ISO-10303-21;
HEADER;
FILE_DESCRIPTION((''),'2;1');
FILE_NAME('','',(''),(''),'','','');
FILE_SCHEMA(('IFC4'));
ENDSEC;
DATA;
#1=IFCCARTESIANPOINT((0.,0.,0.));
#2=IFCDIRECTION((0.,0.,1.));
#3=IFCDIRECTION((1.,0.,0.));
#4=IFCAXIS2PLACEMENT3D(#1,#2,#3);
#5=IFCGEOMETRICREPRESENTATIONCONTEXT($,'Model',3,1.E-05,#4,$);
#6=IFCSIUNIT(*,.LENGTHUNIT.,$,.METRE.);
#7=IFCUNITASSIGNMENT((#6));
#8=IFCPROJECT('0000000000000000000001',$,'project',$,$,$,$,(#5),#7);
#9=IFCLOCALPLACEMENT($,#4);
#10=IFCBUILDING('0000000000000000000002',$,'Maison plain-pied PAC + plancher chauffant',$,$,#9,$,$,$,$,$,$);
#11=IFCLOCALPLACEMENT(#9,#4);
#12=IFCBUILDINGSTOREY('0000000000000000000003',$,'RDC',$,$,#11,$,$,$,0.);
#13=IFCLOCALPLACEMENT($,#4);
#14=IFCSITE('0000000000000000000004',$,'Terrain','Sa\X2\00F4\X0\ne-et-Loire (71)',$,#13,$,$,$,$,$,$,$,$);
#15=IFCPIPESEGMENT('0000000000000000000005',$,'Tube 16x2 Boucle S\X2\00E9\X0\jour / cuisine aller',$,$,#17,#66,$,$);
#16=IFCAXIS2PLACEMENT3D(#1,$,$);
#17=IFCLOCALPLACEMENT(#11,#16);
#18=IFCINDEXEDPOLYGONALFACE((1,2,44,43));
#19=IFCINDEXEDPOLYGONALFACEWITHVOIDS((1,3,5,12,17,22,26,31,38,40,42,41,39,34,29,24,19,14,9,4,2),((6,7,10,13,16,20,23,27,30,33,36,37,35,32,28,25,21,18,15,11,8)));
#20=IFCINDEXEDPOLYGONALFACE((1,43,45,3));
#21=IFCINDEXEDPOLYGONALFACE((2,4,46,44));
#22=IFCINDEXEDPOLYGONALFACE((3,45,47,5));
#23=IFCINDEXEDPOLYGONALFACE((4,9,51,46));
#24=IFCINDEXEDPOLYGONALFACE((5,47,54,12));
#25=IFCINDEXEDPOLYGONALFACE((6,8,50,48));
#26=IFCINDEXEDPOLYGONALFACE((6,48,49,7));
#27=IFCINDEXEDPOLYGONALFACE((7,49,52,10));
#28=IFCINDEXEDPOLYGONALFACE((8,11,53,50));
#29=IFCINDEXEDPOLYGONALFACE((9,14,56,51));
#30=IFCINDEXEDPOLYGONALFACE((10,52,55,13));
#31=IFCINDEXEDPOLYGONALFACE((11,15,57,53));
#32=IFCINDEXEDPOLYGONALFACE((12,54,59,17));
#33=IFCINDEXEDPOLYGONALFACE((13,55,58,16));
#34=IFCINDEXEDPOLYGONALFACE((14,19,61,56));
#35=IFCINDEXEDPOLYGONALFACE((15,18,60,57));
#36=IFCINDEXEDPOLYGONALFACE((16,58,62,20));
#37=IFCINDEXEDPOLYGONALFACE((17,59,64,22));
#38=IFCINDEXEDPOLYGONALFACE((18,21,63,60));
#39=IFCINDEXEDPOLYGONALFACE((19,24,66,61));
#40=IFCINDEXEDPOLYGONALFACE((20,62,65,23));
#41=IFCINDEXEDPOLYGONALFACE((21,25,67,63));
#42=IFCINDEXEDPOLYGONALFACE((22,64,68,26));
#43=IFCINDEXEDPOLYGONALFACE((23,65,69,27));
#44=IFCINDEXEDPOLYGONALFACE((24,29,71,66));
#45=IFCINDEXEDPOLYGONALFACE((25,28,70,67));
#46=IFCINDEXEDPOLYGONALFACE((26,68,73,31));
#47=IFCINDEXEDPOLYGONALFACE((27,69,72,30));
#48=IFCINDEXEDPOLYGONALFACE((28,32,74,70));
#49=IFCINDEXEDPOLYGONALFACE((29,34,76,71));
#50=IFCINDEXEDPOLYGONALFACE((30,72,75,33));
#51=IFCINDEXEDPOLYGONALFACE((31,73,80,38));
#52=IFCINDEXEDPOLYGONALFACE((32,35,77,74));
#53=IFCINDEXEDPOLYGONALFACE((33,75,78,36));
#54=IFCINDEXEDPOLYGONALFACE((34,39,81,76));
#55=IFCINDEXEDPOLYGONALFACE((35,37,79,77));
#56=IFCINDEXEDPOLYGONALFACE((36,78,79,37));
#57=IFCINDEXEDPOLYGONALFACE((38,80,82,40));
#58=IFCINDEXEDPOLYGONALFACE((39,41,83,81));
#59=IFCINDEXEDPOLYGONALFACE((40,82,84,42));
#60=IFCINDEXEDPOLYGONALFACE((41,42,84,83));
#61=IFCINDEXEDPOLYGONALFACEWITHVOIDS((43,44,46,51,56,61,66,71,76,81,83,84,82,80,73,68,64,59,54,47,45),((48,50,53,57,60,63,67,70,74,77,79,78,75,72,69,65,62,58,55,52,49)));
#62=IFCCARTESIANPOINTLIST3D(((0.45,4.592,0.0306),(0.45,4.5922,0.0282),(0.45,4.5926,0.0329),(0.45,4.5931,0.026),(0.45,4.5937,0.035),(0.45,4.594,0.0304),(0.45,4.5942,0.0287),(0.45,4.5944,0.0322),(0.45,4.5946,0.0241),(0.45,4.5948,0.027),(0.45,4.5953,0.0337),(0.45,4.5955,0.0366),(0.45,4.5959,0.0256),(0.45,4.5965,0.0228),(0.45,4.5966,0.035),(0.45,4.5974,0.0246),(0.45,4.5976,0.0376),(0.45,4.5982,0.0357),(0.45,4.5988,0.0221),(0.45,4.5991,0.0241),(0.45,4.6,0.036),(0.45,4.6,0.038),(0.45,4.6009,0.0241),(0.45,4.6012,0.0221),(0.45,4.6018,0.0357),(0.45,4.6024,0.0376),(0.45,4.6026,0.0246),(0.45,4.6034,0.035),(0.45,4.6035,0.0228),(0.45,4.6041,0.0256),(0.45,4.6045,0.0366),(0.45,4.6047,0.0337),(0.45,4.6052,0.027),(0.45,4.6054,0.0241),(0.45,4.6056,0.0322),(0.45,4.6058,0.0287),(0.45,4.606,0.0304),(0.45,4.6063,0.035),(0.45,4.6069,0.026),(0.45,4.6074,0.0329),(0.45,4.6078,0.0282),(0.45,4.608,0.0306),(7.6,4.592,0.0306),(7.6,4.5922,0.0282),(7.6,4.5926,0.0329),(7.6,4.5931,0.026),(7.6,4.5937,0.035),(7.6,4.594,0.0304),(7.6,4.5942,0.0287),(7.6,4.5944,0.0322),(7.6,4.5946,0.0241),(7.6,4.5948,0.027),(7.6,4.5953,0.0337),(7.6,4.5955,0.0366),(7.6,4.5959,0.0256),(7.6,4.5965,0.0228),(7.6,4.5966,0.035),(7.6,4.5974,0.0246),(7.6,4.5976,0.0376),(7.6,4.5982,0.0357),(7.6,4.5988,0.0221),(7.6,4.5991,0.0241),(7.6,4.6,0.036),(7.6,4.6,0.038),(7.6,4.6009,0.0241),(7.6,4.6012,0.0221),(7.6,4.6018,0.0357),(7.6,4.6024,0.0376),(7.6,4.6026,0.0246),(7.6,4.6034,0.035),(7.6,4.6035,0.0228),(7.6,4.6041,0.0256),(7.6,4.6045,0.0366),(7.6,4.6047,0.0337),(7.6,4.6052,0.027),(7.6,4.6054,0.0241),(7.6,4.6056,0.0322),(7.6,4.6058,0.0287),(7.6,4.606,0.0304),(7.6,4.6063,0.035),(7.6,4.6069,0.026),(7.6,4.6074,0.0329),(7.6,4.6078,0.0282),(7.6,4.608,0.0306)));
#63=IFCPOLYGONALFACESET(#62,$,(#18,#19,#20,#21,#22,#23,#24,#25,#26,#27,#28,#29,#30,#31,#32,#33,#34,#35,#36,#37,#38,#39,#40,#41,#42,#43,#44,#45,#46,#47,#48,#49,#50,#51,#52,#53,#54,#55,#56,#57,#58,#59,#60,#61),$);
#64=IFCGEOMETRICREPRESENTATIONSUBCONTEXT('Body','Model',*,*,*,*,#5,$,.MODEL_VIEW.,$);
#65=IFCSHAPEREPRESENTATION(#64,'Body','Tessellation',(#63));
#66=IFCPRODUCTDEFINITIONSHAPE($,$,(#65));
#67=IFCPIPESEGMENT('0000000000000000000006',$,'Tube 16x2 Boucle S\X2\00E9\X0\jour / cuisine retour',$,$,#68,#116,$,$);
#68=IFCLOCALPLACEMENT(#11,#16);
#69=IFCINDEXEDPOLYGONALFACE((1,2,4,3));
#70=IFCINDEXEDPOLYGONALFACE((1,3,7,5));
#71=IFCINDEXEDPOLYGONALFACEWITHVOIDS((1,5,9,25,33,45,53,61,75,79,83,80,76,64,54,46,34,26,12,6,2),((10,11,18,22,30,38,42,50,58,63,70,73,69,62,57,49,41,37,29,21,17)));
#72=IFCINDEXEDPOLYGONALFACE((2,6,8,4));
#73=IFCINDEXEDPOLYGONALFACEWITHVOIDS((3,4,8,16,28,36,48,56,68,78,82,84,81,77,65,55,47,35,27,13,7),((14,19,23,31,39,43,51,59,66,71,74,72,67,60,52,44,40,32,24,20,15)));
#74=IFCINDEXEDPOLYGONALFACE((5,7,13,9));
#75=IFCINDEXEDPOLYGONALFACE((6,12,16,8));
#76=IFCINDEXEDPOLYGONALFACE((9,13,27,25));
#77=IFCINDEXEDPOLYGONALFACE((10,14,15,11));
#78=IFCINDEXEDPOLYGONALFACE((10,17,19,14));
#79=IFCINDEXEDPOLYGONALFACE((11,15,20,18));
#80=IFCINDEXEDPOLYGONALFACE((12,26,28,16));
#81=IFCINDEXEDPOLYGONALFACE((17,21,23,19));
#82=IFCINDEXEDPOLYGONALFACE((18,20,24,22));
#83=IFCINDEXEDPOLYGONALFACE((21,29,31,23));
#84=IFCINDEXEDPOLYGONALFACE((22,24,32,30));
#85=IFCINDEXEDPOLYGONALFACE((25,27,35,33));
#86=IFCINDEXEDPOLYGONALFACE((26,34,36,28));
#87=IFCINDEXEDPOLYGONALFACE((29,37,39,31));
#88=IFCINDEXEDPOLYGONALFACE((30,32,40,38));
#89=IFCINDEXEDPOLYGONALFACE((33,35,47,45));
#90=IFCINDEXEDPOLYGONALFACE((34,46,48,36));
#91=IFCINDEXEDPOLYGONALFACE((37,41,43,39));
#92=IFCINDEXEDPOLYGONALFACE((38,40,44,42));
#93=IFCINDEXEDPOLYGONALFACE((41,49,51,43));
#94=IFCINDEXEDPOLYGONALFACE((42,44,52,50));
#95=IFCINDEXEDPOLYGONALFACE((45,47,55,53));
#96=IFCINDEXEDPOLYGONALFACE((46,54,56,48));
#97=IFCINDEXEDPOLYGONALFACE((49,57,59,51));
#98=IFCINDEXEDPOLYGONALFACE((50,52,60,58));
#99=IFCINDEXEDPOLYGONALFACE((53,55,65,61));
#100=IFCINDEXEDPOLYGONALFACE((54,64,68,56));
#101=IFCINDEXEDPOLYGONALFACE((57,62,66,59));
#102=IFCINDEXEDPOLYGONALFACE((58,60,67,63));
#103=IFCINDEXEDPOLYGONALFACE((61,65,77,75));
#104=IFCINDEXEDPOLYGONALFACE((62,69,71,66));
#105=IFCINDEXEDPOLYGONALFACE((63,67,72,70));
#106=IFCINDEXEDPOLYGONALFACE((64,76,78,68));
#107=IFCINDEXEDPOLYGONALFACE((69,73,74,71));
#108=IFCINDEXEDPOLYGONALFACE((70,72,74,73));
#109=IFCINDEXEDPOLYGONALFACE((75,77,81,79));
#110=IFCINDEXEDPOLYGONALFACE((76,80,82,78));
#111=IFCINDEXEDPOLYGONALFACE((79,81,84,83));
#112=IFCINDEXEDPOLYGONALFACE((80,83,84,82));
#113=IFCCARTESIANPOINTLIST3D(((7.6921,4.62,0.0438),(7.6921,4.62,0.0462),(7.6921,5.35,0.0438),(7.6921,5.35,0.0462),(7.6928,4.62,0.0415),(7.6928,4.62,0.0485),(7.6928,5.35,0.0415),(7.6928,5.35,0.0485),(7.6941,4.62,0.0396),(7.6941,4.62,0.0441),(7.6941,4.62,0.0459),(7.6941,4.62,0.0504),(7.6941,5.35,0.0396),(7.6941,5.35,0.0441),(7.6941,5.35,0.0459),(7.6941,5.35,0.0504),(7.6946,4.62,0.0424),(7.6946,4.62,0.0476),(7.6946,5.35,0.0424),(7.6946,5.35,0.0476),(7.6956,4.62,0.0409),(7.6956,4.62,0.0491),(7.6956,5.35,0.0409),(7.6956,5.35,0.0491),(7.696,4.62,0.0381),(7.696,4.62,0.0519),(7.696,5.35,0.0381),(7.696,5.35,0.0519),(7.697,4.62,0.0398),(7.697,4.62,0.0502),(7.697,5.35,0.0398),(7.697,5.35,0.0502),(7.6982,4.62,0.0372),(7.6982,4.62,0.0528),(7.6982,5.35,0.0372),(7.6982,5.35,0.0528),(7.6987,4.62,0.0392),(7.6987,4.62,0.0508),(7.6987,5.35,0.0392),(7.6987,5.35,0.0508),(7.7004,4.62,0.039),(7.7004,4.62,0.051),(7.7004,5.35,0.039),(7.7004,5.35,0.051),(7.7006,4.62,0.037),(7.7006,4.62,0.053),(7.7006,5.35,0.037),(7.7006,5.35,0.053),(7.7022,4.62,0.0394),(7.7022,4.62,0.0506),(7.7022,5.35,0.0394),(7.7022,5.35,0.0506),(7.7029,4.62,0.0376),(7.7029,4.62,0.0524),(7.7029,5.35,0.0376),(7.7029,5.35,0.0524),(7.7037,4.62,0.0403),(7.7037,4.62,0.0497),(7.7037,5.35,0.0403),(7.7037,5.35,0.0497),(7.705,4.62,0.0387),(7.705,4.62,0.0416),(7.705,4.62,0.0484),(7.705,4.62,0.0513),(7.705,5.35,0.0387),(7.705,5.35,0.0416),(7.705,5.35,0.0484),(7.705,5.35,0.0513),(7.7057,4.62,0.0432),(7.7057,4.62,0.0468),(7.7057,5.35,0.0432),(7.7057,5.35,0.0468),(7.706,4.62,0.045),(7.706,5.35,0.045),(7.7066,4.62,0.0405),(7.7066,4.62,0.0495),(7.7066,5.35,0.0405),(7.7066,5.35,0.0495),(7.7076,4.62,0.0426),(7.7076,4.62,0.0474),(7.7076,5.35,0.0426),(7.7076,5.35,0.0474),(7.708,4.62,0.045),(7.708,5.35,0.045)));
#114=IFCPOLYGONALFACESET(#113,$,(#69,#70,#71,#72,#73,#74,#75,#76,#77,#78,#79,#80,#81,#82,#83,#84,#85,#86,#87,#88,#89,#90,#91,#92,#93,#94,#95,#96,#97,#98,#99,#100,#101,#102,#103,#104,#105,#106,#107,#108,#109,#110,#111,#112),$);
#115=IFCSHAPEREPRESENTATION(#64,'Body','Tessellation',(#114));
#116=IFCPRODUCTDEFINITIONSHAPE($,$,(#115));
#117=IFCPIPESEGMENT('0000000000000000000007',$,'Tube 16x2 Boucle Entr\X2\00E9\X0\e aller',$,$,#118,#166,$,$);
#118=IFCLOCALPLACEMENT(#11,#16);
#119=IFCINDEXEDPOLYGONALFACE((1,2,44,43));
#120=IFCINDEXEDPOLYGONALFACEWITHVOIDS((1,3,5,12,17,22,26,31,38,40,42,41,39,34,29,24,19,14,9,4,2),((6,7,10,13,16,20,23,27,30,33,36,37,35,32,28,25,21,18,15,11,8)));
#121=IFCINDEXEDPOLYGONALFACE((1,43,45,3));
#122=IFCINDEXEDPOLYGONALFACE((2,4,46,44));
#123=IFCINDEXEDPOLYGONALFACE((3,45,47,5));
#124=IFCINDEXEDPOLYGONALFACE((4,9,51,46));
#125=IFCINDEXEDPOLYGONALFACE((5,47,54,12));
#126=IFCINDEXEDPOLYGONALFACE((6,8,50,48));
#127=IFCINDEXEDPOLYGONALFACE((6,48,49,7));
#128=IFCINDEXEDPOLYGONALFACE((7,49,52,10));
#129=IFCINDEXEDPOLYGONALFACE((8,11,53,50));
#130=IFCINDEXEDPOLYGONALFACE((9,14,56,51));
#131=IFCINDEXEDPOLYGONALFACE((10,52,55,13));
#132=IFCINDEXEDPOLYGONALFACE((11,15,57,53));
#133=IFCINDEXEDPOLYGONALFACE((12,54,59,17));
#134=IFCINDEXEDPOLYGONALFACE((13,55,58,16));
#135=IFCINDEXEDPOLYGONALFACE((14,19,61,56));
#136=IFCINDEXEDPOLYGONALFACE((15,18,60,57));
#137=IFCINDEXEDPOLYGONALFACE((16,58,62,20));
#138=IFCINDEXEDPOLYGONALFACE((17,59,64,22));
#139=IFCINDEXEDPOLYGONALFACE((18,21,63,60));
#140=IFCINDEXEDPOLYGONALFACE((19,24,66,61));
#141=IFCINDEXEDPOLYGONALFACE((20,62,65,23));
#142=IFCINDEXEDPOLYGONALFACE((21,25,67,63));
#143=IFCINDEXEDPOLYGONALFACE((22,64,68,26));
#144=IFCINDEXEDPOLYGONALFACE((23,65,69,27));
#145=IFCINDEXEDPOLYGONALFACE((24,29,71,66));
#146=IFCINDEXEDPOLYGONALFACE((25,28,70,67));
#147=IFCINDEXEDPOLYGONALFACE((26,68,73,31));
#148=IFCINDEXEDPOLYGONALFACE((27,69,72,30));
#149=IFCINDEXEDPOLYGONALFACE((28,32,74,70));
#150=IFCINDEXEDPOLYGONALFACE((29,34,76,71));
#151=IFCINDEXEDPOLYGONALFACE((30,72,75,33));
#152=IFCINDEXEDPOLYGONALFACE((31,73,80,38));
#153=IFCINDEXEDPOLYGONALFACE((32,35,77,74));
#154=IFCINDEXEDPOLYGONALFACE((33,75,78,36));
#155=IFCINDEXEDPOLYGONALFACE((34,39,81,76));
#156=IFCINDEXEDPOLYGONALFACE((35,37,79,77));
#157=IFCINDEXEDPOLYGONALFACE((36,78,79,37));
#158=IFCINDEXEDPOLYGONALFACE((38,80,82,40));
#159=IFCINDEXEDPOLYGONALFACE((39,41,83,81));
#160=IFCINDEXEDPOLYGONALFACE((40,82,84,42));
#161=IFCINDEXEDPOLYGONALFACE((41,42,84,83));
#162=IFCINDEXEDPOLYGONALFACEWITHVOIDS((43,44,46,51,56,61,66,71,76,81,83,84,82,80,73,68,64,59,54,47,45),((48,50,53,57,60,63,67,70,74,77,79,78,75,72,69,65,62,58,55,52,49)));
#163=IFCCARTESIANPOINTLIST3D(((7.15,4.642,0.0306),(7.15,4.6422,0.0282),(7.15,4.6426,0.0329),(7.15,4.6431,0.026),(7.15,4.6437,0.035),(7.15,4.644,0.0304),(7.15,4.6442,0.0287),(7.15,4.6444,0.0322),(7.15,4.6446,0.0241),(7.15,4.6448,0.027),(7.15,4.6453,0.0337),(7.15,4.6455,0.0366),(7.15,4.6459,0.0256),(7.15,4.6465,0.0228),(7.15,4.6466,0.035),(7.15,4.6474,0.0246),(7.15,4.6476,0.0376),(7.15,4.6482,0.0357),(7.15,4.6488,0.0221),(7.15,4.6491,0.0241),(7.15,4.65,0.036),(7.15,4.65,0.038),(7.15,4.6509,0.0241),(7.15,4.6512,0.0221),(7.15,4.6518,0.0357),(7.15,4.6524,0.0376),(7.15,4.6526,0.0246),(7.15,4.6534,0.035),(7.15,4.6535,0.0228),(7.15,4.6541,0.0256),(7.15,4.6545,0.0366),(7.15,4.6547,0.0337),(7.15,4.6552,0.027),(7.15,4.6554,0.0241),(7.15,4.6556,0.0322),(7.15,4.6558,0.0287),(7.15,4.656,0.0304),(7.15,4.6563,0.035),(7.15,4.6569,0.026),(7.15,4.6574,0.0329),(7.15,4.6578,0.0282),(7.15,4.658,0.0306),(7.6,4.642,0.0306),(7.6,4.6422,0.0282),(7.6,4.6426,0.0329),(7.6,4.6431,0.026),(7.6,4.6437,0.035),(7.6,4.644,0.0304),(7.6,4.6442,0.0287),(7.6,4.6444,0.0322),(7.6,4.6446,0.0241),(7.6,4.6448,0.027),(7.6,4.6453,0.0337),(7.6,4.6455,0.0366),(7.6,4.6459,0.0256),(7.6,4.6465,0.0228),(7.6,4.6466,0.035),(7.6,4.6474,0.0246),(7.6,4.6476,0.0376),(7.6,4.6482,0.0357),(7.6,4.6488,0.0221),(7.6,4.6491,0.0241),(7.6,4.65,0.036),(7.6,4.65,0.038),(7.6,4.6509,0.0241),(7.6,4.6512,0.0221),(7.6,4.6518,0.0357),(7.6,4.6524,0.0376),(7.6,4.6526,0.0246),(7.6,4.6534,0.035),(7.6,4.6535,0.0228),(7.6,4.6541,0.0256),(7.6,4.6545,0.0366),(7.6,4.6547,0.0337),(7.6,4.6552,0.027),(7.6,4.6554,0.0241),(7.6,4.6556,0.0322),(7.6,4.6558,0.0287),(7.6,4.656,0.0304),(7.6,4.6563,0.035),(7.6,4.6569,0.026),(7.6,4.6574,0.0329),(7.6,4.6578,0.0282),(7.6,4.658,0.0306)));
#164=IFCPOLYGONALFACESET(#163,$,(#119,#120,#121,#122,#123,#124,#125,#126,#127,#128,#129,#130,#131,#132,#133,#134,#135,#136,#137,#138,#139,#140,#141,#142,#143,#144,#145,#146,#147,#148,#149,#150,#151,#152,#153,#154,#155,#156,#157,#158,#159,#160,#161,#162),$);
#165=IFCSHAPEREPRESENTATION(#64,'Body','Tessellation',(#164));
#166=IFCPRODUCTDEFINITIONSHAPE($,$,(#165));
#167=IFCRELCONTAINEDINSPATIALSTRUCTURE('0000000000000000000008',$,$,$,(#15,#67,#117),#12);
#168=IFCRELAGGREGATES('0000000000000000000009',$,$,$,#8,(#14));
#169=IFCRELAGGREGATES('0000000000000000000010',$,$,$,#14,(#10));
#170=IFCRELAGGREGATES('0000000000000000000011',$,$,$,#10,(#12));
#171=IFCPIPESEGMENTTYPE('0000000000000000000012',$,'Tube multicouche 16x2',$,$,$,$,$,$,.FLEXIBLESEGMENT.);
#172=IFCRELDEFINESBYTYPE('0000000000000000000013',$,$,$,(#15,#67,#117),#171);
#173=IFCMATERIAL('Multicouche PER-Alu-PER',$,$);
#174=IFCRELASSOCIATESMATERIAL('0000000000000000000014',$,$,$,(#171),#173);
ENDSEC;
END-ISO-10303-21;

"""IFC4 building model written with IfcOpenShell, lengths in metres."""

from ifc_helpers import new_model, si_unit, frame, origin_with_axes, place, context, subcontext, project, spatial, hollow_circle, extrude, material, type_object, element, save


model = new_model("IFC4")

# Units and contexts
model_context = context("Model", 3, precision=1e-05, world=origin_with_axes())
body_context = subcontext(model_context, "Body", "Model", "MODEL_VIEW")
ifc_project = project(units=[si_unit("LENGTHUNIT", "METRE")], contexts=[model_context])

# Site, building, storey
site_placement = place(None, origin_with_axes())
site = spatial("IfcSite", under=ifc_project, at=site_placement, Name="Terrain", Description="Saône-et-Loire (71)")
building_placement = place(None, origin_with_axes())
building = spatial("IfcBuilding", under=site, at=building_placement, Name="Maison plain-pied PAC + plancher chauffant")
storey_placement = place(building_placement, origin_with_axes())
storey = spatial("IfcBuildingStorey", under=building, at=storey_placement, Name="RDC", Elevation=0.0)

# Pipe segments
ifc_material = material(Name="Multicouche PER-Alu-PER")
pipe_segment_type = type_object("IfcPipeSegmentType", Name="Tube multicouche 16x2", PredefinedType="FLEXIBLESEGMENT", material=ifc_material)
pipe_segment_1_placement = place(storey_placement, frame((7.6, 4.6, 0.03), z_axis=(-1.0, 0.0, 0.0), x_axis=(0.0, 0.0, 1.0)))
element("IfcPipeSegment", 1, at=pipe_segment_1_placement, inside=storey, type_object=pipe_segment_type, Name="Tube 16x2 Boucle Séjour / cuisine aller", context=body_context, shape_type="SweptSolid", body=[
    extrude(hollow_circle(Radius=0.008, WallThickness=0.002), origin_with_axes(), (0.0, 0.0, 1.0), 7.15),
])
pipe_segment_2_placement = place(storey_placement, frame((7.7, 4.62, 0.045), z_axis=(0.0, 1.0, 0.0), x_axis=(1.0, 0.0, 0.0)))
element("IfcPipeSegment", 2, at=pipe_segment_2_placement, inside=storey, type_object=pipe_segment_type, Name="Tube 16x2 Boucle Séjour / cuisine retour", context=body_context, shape_type="SweptSolid", body=[
    extrude(hollow_circle(Radius=0.008, WallThickness=0.002), origin_with_axes(), (0.0, 0.0, 1.0), 0.73),
])
pipe_segment_3_placement = place(storey_placement, frame((7.6, 4.65, 0.03), z_axis=(-1.0, 0.0, 0.0), x_axis=(0.0, 0.0, 1.0)))
element("IfcPipeSegment", 3, at=pipe_segment_3_placement, inside=storey, type_object=pipe_segment_type, Name="Tube 16x2 Boucle Entrée aller", context=body_context, shape_type="SweptSolid", body=[
    extrude(hollow_circle(Radius=0.008, WallThickness=0.002), origin_with_axes(), (0.0, 0.0, 1.0), 0.45),
])

save(model, "model.ifc")
